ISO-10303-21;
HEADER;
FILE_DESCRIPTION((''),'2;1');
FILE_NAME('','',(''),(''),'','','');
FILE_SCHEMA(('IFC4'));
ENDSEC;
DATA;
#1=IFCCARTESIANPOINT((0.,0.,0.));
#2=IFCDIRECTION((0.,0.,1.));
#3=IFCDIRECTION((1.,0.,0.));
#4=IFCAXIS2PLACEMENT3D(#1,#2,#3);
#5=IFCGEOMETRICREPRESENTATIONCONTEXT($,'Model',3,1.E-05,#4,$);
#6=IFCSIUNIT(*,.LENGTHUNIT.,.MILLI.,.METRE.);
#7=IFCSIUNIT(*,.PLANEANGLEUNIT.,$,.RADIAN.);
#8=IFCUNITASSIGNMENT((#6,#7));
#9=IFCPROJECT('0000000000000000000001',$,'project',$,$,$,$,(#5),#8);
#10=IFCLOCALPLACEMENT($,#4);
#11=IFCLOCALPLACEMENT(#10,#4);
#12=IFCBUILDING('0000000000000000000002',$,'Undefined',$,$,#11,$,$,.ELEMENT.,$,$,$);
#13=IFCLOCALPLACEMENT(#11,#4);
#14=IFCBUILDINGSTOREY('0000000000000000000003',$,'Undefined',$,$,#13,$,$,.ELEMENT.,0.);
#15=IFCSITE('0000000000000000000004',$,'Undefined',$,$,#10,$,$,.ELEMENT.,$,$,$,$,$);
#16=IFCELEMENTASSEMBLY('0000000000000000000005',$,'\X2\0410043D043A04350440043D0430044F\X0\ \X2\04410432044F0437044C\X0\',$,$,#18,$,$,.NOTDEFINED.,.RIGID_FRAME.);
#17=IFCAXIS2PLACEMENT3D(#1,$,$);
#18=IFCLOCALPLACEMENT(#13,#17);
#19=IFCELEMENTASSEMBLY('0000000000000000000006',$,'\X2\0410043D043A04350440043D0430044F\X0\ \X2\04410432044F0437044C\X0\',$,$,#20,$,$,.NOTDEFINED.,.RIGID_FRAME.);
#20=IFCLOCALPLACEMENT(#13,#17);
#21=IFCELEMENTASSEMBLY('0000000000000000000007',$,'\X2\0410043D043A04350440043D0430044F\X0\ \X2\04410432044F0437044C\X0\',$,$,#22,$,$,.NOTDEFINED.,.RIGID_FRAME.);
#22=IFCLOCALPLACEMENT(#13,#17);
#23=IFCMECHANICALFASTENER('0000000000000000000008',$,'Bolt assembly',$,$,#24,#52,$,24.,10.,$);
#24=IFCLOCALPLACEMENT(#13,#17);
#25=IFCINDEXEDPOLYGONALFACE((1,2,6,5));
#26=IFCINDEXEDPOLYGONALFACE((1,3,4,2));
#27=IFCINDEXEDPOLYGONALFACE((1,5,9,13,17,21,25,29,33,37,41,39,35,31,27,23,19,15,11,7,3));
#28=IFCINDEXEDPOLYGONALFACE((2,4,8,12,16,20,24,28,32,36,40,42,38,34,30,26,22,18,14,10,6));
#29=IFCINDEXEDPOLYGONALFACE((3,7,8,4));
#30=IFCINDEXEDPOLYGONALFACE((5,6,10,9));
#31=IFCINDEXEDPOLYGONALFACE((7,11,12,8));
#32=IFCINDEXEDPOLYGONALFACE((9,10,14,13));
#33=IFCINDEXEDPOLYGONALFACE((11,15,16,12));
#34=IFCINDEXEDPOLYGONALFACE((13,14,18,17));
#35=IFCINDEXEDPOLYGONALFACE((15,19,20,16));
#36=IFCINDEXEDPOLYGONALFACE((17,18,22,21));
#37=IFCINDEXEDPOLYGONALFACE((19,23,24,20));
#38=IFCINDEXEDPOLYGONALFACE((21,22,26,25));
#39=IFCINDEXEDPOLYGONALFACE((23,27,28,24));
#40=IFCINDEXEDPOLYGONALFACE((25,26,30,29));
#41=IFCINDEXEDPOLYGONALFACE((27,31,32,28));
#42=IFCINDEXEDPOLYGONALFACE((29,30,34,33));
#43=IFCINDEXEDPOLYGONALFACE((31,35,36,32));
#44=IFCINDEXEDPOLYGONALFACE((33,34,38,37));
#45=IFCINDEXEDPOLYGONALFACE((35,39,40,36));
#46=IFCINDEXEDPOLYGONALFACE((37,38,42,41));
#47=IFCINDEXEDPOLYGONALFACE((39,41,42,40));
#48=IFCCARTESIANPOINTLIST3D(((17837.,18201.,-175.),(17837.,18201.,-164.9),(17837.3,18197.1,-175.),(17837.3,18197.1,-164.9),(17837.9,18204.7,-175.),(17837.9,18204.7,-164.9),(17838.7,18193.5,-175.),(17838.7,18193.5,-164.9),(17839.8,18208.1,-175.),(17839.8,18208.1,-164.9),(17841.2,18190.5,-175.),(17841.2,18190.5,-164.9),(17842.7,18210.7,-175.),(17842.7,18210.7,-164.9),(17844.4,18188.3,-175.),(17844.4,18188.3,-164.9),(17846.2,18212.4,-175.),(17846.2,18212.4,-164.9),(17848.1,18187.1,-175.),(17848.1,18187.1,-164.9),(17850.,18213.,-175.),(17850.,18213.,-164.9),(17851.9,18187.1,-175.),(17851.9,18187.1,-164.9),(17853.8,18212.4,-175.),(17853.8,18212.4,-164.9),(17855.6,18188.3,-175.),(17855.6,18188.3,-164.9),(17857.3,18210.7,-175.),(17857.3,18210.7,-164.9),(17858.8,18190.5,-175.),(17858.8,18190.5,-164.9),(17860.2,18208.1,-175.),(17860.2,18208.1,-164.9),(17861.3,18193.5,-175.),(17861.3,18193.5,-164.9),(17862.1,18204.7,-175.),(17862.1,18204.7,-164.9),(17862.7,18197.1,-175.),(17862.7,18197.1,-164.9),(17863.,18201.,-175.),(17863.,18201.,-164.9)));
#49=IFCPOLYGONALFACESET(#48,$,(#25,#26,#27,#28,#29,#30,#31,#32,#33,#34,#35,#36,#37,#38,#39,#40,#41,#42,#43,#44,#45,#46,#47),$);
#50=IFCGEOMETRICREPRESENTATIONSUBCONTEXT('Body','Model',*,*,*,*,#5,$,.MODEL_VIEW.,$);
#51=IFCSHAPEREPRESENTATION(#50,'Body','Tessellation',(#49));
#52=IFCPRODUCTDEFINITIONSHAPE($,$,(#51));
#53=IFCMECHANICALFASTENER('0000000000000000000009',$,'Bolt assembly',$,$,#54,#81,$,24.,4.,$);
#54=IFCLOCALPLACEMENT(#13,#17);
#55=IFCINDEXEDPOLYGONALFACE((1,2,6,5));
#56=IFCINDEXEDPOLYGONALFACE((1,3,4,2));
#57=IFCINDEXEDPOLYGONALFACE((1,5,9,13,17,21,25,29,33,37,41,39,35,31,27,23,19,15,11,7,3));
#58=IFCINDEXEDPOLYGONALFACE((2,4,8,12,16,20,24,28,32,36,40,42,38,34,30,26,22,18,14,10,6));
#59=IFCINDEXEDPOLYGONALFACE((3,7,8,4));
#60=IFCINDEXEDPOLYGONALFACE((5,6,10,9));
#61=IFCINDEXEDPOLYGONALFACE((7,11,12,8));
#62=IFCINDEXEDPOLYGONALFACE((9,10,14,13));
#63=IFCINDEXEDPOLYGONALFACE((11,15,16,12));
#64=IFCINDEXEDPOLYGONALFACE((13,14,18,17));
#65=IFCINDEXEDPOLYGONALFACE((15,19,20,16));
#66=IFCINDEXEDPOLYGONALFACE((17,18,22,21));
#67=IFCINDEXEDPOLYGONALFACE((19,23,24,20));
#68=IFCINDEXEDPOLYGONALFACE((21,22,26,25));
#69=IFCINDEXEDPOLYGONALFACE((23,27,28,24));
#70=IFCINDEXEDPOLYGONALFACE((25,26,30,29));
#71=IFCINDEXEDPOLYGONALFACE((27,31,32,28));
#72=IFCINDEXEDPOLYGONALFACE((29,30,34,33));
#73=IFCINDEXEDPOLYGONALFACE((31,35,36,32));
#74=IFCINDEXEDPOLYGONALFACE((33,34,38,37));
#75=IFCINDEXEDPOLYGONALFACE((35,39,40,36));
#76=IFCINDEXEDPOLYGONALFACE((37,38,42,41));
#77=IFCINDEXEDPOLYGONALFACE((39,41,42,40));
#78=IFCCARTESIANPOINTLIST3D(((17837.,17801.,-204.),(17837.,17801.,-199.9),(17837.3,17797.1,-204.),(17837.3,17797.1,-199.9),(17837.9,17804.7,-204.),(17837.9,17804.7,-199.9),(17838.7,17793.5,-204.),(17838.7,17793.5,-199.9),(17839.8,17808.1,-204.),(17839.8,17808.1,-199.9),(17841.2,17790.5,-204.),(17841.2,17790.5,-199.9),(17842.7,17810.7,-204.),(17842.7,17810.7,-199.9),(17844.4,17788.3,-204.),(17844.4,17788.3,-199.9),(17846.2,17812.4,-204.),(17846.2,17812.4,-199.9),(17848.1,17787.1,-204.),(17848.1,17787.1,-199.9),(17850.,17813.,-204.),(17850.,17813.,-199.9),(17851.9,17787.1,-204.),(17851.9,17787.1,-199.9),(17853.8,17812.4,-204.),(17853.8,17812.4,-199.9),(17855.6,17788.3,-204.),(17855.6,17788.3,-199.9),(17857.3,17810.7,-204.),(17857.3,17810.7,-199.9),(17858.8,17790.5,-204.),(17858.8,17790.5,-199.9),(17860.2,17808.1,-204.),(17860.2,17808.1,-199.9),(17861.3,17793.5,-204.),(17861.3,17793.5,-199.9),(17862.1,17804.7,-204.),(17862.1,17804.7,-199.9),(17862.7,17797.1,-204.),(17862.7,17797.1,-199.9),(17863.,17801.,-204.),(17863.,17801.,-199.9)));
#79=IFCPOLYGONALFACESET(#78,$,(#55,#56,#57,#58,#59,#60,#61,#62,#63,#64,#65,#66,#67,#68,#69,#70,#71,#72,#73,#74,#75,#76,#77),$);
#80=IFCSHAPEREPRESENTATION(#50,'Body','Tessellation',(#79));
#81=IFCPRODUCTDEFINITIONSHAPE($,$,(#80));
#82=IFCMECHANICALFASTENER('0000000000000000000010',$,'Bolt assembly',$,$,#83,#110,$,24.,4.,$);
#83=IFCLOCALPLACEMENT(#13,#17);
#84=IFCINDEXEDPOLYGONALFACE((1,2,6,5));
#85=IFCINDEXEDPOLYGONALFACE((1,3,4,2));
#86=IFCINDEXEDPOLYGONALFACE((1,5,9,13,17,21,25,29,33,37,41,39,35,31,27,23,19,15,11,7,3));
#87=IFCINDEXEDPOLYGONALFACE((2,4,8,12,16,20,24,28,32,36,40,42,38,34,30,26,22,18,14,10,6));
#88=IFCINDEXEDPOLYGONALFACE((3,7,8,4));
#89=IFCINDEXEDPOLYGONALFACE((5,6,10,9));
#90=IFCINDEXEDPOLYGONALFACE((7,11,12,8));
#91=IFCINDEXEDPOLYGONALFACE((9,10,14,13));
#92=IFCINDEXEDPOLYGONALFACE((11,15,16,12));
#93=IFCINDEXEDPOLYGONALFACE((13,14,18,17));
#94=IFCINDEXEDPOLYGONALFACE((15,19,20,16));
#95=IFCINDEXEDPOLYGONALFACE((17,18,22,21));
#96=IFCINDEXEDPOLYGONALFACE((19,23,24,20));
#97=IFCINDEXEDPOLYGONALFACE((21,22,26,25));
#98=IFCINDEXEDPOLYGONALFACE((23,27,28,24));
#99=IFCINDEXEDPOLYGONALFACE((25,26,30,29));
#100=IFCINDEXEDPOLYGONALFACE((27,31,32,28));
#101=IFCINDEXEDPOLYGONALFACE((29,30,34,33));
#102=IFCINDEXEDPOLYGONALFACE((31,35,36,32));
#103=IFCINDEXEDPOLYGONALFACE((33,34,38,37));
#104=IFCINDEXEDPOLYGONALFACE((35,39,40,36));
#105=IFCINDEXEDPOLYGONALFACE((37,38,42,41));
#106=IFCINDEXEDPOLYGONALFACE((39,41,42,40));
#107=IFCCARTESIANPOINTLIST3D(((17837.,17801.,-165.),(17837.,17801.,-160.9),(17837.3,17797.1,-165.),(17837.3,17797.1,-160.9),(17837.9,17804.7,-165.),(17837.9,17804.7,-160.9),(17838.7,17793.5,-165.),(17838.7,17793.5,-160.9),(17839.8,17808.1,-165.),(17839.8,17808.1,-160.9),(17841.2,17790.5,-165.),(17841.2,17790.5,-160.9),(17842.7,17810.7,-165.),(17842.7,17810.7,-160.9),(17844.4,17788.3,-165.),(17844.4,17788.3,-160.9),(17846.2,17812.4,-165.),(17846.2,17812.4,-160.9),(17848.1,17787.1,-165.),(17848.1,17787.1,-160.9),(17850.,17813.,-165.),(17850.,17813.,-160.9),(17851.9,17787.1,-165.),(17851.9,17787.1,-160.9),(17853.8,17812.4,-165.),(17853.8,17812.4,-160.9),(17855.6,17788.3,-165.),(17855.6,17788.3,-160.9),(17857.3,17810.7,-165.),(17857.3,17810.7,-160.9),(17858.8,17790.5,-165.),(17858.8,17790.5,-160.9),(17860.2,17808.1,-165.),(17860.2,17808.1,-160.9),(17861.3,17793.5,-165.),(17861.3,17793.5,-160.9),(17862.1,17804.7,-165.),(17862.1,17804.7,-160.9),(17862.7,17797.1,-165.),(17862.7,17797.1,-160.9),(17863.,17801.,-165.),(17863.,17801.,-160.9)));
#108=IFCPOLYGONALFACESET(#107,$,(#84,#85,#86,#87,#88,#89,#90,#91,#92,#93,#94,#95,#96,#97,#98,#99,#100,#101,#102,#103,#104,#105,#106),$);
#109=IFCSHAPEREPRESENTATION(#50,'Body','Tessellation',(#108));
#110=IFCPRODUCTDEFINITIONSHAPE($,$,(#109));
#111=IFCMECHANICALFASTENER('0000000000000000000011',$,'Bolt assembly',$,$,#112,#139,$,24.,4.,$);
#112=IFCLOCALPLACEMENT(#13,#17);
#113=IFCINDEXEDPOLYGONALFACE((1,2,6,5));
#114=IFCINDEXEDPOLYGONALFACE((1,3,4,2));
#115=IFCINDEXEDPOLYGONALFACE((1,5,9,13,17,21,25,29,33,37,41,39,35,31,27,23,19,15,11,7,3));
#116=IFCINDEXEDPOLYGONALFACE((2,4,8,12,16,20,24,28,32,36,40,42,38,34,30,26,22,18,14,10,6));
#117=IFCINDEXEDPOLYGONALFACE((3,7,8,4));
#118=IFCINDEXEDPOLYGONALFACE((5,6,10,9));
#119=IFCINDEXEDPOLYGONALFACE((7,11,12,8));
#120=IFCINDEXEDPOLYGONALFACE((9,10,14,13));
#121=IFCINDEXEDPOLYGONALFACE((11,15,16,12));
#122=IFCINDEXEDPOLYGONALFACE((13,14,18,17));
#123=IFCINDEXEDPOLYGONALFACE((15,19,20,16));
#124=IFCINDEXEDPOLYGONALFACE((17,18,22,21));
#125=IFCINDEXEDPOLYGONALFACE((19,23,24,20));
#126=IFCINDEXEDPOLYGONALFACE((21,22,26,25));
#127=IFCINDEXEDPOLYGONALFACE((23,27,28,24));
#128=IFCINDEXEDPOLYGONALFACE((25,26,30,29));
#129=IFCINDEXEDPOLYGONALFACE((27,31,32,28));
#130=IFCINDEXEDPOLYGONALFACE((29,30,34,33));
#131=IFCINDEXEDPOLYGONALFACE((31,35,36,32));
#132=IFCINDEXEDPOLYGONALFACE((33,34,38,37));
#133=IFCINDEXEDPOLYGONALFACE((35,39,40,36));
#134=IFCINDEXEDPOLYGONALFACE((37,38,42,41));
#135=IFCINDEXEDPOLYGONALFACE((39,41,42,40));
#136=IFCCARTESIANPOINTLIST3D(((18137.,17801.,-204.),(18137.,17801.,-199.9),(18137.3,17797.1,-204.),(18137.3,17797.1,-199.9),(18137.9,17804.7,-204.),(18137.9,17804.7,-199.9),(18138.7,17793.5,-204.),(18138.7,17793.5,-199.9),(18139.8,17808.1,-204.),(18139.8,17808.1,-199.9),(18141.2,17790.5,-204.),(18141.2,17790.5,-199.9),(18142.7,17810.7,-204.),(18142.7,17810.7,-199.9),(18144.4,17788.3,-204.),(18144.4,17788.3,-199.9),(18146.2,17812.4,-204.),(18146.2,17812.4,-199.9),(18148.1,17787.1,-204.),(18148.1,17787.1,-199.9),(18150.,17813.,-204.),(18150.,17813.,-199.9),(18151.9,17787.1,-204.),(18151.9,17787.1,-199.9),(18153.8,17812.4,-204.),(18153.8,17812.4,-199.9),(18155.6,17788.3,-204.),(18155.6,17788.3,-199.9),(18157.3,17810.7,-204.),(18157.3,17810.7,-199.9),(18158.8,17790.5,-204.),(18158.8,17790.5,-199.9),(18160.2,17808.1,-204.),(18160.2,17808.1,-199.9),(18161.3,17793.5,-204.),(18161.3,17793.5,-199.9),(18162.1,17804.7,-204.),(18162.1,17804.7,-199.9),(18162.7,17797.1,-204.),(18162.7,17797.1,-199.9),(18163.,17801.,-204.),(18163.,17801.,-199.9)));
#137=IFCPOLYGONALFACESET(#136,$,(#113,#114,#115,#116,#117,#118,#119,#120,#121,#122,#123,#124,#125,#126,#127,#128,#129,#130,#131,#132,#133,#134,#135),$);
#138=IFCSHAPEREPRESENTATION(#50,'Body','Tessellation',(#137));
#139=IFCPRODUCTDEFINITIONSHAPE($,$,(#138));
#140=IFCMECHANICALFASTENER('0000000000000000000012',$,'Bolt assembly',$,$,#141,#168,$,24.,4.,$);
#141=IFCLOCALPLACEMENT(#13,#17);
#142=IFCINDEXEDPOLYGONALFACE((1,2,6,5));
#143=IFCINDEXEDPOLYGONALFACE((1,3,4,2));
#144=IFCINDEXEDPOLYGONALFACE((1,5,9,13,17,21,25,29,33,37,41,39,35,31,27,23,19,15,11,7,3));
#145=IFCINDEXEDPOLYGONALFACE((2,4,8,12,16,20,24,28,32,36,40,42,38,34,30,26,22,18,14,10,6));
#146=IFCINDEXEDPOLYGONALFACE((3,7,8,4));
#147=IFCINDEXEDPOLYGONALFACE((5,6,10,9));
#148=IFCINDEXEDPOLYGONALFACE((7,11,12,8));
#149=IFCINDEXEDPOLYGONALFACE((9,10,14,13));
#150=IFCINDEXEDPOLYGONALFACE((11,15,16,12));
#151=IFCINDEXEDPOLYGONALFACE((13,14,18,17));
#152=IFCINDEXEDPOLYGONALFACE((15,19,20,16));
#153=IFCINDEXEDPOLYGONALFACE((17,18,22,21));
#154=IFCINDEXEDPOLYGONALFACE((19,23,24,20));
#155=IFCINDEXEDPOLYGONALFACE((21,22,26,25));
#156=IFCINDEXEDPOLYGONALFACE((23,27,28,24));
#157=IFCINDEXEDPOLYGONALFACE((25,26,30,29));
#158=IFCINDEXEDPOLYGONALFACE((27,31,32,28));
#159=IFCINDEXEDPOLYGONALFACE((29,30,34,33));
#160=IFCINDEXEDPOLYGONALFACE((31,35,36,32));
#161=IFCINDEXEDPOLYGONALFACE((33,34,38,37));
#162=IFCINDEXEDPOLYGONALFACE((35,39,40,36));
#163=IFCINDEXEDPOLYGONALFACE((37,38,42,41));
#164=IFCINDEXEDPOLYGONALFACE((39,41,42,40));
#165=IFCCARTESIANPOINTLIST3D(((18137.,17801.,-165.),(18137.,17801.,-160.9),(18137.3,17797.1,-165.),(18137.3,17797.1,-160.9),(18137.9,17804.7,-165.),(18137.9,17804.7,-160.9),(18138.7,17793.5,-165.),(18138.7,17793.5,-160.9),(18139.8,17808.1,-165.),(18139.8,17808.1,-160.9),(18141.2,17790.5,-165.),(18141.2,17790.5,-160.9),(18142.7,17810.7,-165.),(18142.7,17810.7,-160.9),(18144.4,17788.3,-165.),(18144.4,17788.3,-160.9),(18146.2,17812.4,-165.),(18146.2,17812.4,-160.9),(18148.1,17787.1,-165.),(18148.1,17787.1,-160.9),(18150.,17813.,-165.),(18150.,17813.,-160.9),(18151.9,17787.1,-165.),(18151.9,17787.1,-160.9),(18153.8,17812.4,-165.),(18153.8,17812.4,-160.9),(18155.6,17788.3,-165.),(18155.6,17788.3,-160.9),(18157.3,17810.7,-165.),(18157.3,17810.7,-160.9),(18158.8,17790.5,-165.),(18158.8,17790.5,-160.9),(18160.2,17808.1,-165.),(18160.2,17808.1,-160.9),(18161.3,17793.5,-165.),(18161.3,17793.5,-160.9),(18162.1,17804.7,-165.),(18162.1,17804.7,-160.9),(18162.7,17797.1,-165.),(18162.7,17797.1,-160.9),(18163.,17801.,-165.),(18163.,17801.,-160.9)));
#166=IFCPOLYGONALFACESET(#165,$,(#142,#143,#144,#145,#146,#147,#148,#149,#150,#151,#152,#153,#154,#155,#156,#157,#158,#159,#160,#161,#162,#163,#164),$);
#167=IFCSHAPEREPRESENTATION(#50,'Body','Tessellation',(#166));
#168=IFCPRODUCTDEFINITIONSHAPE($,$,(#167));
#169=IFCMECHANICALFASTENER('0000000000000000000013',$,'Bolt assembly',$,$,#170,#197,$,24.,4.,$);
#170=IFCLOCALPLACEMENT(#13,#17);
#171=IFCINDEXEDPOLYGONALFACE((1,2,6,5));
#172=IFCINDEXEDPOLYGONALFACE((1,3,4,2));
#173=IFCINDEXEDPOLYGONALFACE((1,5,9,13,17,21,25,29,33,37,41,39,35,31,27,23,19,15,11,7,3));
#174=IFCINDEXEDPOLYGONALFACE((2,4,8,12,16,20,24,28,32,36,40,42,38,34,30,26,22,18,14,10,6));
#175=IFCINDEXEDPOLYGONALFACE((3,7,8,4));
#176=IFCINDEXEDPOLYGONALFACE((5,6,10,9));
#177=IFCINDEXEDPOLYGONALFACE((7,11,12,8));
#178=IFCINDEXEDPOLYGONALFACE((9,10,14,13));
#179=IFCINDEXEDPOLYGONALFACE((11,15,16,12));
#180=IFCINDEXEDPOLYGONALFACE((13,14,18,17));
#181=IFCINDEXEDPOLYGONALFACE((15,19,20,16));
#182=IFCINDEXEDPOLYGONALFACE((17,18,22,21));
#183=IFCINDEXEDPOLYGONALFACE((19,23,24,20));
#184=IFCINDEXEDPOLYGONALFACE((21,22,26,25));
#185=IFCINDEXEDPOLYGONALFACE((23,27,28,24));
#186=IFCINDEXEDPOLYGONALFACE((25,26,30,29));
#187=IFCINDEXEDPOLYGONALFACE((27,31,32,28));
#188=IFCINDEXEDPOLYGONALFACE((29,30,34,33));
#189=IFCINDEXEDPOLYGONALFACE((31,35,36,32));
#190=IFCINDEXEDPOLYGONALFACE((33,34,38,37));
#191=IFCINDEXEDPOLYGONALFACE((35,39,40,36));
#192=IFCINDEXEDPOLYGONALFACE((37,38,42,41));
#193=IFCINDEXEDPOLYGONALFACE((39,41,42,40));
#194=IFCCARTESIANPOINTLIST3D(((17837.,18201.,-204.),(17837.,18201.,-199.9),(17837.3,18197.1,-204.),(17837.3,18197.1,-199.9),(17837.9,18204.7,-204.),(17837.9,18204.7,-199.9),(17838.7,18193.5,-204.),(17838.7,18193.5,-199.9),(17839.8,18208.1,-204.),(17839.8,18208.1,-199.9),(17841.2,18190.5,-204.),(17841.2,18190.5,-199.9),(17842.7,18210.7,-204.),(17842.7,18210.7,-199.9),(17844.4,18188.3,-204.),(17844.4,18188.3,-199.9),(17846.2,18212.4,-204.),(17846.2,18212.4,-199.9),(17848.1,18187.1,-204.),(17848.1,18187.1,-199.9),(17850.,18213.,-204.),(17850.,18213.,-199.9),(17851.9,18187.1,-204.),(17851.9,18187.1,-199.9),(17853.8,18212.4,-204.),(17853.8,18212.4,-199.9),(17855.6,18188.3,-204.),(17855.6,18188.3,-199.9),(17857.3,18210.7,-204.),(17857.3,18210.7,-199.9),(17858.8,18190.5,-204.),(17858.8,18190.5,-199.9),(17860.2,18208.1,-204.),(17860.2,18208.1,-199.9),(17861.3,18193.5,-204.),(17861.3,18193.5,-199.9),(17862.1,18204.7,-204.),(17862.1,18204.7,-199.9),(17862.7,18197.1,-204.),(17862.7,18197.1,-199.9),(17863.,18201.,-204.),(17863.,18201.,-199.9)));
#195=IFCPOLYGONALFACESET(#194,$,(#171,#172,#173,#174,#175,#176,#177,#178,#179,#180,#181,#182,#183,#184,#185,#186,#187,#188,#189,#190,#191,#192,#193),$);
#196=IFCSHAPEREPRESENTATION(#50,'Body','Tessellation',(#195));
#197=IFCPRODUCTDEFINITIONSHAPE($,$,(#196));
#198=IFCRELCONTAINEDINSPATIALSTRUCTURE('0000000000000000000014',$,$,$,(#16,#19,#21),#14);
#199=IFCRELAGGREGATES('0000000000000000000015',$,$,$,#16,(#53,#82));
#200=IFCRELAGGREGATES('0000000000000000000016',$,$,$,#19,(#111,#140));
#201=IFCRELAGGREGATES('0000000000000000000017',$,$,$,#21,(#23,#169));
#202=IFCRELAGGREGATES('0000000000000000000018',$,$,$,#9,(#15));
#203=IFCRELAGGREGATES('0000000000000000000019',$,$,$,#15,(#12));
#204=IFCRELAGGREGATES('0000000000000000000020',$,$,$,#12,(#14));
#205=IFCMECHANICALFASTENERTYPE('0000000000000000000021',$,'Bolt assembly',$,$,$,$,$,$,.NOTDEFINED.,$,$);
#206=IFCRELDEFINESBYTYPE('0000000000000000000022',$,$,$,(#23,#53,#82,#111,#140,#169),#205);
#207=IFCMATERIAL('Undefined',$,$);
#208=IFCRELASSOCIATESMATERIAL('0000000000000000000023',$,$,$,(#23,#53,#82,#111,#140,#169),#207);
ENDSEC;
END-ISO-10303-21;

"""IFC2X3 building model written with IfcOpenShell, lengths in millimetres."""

from ifc_helpers import new_model, si_unit, frame, origin_with_axes, origin_2d_with_axis, place, context, subcontext, project, spatial, circle, extrude, source, transform, mapped, material, type_object, element, aggregate, save


model = new_model("IFC2X3")

# Units and contexts
model_context = context("Model", 3, precision=1e-05, world=origin_with_axes())
body_context = subcontext(model_context, "Body", "Model", "MODEL_VIEW")
ifc_project = project(units=[si_unit("LENGTHUNIT", "METRE", prefix="MILLI"), si_unit("PLANEANGLEUNIT", "RADIAN")], contexts=[model_context])

# Site, building, storey
site_placement = place(None, origin_with_axes())
site = spatial("IfcSite", under=ifc_project, at=site_placement, Name="Undefined", CompositionType="ELEMENT")
building_placement = place(site_placement, origin_with_axes())
building = spatial("IfcBuilding", under=site, at=building_placement, Name="Undefined", CompositionType="ELEMENT")
storey_placement = place(building_placement, origin_with_axes())
storey = spatial("IfcBuildingStorey", under=building, at=storey_placement, Name="Undefined", CompositionType="ELEMENT", Elevation=0.0)

# Element assemblies
assembly_1_placement = place(storey_placement, origin_with_axes())
assembly_1 = element("IfcElementAssembly", 1, at=assembly_1_placement, inside=storey, Name="Анкерная связь", AssemblyPlace="NOTDEFINED", PredefinedType="RIGID_FRAME")
assembly_2_placement = place(storey_placement, origin_with_axes())
assembly_2 = element("IfcElementAssembly", 2, at=assembly_2_placement, inside=storey, Name="Анкерная связь", AssemblyPlace="NOTDEFINED", PredefinedType="RIGID_FRAME")
assembly_3_placement = place(storey_placement, origin_with_axes())
assembly_3 = element("IfcElementAssembly", 3, at=assembly_3_placement, inside=storey, Name="Анкерная связь", AssemblyPlace="NOTDEFINED", PredefinedType="RIGID_FRAME")

# Mechanical fasteners
ifc_material_1 = material(Name="Undefined")
mechanical_fastener_type = type_object("IfcMechanicalFastenerType", Name="Bolt assembly")
shared_shape_1 = source(origin_with_axes(), body_context, "Body", "SweptSolid", [
    extrude(circle(Radius=13.0, at=origin_2d_with_axis()), frame((0.0, 0.0, 0.0), z_axis=(0.0, 1.0, 0.0), x_axis=(1.0, 0.0, 0.0)), (0.0, 0.0, 1.0), 10.1),
])
mechanical_fastener_1_placement = place(assembly_3_placement, frame((17850.0, 18200.0, -175.0), z_axis=(1.0, 0.0, 0.0), x_axis=(0.0, 1.0, 0.0)))
mechanical_fastener_1 = element("IfcMechanicalFastener", 4, at=mechanical_fastener_1_placement, type_object=mechanical_fastener_type, material=ifc_material_1, Name="Bolt assembly", NominalDiameter=24.0, NominalLength=10.0, context=body_context, shape_type="MappedRepresentation", body=[
    mapped(shared_shape_1, transform((0.0, 0.0, 0.0))),
])
shared_shape_2 = source(origin_with_axes(), body_context, "Body", "SweptSolid", [
    extrude(circle(Radius=13.0, at=origin_2d_with_axis()), frame((0.0, -4.0, 0.0), z_axis=(0.0, 1.0, 0.0), x_axis=(1.0, 0.0, 0.0)), (0.0, 0.0, 1.0), 4.1),
])
mechanical_fastener_2_placement = place(assembly_1_placement, frame((17850.0, 17800.0, -200.0), z_axis=(1.0, 0.0, 0.0), x_axis=(0.0, 1.0, 0.0)))
mechanical_fastener_2 = element("IfcMechanicalFastener", 5, at=mechanical_fastener_2_placement, type_object=mechanical_fastener_type, material=ifc_material_1, Name="Bolt assembly", NominalDiameter=24.0, NominalLength=4.0, context=body_context, shape_type="MappedRepresentation", body=[
    mapped(shared_shape_2, transform((0.0, 0.0, 0.0))),
])
mechanical_fastener_3_placement = place(assembly_1_placement, frame((17850.0, 17800.0, -161.0), z_axis=(1.0, 0.0, 0.0), x_axis=(0.0, 1.0, 0.0)))
mechanical_fastener_3 = element("IfcMechanicalFastener", 6, at=mechanical_fastener_3_placement, type_object=mechanical_fastener_type, material=ifc_material_1, Name="Bolt assembly", NominalDiameter=24.0, NominalLength=4.0, context=body_context, shape_type="MappedRepresentation", body=[
    mapped(shared_shape_2, transform((0.0, 0.0, 0.0))),
])
aggregate(assembly_1, [mechanical_fastener_2, mechanical_fastener_3])
mechanical_fastener_4_placement = place(assembly_2_placement, frame((18150.0, 17800.0, -200.0), z_axis=(1.0, 0.0, 0.0), x_axis=(0.0, 1.0, 0.0)))
mechanical_fastener_4 = element("IfcMechanicalFastener", 7, at=mechanical_fastener_4_placement, type_object=mechanical_fastener_type, material=ifc_material_1, Name="Bolt assembly", NominalDiameter=24.0, NominalLength=4.0, context=body_context, shape_type="MappedRepresentation", body=[
    mapped(shared_shape_2, transform((0.0, 0.0, 0.0))),
])
mechanical_fastener_5_placement = place(assembly_2_placement, frame((18150.0, 17800.0, -161.0), z_axis=(1.0, 0.0, 0.0), x_axis=(0.0, 1.0, 0.0)))
mechanical_fastener_5 = element("IfcMechanicalFastener", 8, at=mechanical_fastener_5_placement, type_object=mechanical_fastener_type, material=ifc_material_1, Name="Bolt assembly", NominalDiameter=24.0, NominalLength=4.0, context=body_context, shape_type="MappedRepresentation", body=[
    mapped(shared_shape_2, transform((0.0, 0.0, 0.0))),
])
aggregate(assembly_2, [mechanical_fastener_4, mechanical_fastener_5])
mechanical_fastener_6_placement = place(assembly_3_placement, frame((17850.0, 18200.0, -200.0), z_axis=(1.0, 0.0, 0.0), x_axis=(0.0, 1.0, 0.0)))
mechanical_fastener_6 = element("IfcMechanicalFastener", 9, at=mechanical_fastener_6_placement, type_object=mechanical_fastener_type, material=ifc_material_1, Name="Bolt assembly", NominalDiameter=24.0, NominalLength=4.0, context=body_context, shape_type="MappedRepresentation", body=[
    mapped(shared_shape_2, transform((0.0, 0.0, 0.0))),
])
aggregate(assembly_3, [mechanical_fastener_1, mechanical_fastener_6])

save(model, "model.ifc")
